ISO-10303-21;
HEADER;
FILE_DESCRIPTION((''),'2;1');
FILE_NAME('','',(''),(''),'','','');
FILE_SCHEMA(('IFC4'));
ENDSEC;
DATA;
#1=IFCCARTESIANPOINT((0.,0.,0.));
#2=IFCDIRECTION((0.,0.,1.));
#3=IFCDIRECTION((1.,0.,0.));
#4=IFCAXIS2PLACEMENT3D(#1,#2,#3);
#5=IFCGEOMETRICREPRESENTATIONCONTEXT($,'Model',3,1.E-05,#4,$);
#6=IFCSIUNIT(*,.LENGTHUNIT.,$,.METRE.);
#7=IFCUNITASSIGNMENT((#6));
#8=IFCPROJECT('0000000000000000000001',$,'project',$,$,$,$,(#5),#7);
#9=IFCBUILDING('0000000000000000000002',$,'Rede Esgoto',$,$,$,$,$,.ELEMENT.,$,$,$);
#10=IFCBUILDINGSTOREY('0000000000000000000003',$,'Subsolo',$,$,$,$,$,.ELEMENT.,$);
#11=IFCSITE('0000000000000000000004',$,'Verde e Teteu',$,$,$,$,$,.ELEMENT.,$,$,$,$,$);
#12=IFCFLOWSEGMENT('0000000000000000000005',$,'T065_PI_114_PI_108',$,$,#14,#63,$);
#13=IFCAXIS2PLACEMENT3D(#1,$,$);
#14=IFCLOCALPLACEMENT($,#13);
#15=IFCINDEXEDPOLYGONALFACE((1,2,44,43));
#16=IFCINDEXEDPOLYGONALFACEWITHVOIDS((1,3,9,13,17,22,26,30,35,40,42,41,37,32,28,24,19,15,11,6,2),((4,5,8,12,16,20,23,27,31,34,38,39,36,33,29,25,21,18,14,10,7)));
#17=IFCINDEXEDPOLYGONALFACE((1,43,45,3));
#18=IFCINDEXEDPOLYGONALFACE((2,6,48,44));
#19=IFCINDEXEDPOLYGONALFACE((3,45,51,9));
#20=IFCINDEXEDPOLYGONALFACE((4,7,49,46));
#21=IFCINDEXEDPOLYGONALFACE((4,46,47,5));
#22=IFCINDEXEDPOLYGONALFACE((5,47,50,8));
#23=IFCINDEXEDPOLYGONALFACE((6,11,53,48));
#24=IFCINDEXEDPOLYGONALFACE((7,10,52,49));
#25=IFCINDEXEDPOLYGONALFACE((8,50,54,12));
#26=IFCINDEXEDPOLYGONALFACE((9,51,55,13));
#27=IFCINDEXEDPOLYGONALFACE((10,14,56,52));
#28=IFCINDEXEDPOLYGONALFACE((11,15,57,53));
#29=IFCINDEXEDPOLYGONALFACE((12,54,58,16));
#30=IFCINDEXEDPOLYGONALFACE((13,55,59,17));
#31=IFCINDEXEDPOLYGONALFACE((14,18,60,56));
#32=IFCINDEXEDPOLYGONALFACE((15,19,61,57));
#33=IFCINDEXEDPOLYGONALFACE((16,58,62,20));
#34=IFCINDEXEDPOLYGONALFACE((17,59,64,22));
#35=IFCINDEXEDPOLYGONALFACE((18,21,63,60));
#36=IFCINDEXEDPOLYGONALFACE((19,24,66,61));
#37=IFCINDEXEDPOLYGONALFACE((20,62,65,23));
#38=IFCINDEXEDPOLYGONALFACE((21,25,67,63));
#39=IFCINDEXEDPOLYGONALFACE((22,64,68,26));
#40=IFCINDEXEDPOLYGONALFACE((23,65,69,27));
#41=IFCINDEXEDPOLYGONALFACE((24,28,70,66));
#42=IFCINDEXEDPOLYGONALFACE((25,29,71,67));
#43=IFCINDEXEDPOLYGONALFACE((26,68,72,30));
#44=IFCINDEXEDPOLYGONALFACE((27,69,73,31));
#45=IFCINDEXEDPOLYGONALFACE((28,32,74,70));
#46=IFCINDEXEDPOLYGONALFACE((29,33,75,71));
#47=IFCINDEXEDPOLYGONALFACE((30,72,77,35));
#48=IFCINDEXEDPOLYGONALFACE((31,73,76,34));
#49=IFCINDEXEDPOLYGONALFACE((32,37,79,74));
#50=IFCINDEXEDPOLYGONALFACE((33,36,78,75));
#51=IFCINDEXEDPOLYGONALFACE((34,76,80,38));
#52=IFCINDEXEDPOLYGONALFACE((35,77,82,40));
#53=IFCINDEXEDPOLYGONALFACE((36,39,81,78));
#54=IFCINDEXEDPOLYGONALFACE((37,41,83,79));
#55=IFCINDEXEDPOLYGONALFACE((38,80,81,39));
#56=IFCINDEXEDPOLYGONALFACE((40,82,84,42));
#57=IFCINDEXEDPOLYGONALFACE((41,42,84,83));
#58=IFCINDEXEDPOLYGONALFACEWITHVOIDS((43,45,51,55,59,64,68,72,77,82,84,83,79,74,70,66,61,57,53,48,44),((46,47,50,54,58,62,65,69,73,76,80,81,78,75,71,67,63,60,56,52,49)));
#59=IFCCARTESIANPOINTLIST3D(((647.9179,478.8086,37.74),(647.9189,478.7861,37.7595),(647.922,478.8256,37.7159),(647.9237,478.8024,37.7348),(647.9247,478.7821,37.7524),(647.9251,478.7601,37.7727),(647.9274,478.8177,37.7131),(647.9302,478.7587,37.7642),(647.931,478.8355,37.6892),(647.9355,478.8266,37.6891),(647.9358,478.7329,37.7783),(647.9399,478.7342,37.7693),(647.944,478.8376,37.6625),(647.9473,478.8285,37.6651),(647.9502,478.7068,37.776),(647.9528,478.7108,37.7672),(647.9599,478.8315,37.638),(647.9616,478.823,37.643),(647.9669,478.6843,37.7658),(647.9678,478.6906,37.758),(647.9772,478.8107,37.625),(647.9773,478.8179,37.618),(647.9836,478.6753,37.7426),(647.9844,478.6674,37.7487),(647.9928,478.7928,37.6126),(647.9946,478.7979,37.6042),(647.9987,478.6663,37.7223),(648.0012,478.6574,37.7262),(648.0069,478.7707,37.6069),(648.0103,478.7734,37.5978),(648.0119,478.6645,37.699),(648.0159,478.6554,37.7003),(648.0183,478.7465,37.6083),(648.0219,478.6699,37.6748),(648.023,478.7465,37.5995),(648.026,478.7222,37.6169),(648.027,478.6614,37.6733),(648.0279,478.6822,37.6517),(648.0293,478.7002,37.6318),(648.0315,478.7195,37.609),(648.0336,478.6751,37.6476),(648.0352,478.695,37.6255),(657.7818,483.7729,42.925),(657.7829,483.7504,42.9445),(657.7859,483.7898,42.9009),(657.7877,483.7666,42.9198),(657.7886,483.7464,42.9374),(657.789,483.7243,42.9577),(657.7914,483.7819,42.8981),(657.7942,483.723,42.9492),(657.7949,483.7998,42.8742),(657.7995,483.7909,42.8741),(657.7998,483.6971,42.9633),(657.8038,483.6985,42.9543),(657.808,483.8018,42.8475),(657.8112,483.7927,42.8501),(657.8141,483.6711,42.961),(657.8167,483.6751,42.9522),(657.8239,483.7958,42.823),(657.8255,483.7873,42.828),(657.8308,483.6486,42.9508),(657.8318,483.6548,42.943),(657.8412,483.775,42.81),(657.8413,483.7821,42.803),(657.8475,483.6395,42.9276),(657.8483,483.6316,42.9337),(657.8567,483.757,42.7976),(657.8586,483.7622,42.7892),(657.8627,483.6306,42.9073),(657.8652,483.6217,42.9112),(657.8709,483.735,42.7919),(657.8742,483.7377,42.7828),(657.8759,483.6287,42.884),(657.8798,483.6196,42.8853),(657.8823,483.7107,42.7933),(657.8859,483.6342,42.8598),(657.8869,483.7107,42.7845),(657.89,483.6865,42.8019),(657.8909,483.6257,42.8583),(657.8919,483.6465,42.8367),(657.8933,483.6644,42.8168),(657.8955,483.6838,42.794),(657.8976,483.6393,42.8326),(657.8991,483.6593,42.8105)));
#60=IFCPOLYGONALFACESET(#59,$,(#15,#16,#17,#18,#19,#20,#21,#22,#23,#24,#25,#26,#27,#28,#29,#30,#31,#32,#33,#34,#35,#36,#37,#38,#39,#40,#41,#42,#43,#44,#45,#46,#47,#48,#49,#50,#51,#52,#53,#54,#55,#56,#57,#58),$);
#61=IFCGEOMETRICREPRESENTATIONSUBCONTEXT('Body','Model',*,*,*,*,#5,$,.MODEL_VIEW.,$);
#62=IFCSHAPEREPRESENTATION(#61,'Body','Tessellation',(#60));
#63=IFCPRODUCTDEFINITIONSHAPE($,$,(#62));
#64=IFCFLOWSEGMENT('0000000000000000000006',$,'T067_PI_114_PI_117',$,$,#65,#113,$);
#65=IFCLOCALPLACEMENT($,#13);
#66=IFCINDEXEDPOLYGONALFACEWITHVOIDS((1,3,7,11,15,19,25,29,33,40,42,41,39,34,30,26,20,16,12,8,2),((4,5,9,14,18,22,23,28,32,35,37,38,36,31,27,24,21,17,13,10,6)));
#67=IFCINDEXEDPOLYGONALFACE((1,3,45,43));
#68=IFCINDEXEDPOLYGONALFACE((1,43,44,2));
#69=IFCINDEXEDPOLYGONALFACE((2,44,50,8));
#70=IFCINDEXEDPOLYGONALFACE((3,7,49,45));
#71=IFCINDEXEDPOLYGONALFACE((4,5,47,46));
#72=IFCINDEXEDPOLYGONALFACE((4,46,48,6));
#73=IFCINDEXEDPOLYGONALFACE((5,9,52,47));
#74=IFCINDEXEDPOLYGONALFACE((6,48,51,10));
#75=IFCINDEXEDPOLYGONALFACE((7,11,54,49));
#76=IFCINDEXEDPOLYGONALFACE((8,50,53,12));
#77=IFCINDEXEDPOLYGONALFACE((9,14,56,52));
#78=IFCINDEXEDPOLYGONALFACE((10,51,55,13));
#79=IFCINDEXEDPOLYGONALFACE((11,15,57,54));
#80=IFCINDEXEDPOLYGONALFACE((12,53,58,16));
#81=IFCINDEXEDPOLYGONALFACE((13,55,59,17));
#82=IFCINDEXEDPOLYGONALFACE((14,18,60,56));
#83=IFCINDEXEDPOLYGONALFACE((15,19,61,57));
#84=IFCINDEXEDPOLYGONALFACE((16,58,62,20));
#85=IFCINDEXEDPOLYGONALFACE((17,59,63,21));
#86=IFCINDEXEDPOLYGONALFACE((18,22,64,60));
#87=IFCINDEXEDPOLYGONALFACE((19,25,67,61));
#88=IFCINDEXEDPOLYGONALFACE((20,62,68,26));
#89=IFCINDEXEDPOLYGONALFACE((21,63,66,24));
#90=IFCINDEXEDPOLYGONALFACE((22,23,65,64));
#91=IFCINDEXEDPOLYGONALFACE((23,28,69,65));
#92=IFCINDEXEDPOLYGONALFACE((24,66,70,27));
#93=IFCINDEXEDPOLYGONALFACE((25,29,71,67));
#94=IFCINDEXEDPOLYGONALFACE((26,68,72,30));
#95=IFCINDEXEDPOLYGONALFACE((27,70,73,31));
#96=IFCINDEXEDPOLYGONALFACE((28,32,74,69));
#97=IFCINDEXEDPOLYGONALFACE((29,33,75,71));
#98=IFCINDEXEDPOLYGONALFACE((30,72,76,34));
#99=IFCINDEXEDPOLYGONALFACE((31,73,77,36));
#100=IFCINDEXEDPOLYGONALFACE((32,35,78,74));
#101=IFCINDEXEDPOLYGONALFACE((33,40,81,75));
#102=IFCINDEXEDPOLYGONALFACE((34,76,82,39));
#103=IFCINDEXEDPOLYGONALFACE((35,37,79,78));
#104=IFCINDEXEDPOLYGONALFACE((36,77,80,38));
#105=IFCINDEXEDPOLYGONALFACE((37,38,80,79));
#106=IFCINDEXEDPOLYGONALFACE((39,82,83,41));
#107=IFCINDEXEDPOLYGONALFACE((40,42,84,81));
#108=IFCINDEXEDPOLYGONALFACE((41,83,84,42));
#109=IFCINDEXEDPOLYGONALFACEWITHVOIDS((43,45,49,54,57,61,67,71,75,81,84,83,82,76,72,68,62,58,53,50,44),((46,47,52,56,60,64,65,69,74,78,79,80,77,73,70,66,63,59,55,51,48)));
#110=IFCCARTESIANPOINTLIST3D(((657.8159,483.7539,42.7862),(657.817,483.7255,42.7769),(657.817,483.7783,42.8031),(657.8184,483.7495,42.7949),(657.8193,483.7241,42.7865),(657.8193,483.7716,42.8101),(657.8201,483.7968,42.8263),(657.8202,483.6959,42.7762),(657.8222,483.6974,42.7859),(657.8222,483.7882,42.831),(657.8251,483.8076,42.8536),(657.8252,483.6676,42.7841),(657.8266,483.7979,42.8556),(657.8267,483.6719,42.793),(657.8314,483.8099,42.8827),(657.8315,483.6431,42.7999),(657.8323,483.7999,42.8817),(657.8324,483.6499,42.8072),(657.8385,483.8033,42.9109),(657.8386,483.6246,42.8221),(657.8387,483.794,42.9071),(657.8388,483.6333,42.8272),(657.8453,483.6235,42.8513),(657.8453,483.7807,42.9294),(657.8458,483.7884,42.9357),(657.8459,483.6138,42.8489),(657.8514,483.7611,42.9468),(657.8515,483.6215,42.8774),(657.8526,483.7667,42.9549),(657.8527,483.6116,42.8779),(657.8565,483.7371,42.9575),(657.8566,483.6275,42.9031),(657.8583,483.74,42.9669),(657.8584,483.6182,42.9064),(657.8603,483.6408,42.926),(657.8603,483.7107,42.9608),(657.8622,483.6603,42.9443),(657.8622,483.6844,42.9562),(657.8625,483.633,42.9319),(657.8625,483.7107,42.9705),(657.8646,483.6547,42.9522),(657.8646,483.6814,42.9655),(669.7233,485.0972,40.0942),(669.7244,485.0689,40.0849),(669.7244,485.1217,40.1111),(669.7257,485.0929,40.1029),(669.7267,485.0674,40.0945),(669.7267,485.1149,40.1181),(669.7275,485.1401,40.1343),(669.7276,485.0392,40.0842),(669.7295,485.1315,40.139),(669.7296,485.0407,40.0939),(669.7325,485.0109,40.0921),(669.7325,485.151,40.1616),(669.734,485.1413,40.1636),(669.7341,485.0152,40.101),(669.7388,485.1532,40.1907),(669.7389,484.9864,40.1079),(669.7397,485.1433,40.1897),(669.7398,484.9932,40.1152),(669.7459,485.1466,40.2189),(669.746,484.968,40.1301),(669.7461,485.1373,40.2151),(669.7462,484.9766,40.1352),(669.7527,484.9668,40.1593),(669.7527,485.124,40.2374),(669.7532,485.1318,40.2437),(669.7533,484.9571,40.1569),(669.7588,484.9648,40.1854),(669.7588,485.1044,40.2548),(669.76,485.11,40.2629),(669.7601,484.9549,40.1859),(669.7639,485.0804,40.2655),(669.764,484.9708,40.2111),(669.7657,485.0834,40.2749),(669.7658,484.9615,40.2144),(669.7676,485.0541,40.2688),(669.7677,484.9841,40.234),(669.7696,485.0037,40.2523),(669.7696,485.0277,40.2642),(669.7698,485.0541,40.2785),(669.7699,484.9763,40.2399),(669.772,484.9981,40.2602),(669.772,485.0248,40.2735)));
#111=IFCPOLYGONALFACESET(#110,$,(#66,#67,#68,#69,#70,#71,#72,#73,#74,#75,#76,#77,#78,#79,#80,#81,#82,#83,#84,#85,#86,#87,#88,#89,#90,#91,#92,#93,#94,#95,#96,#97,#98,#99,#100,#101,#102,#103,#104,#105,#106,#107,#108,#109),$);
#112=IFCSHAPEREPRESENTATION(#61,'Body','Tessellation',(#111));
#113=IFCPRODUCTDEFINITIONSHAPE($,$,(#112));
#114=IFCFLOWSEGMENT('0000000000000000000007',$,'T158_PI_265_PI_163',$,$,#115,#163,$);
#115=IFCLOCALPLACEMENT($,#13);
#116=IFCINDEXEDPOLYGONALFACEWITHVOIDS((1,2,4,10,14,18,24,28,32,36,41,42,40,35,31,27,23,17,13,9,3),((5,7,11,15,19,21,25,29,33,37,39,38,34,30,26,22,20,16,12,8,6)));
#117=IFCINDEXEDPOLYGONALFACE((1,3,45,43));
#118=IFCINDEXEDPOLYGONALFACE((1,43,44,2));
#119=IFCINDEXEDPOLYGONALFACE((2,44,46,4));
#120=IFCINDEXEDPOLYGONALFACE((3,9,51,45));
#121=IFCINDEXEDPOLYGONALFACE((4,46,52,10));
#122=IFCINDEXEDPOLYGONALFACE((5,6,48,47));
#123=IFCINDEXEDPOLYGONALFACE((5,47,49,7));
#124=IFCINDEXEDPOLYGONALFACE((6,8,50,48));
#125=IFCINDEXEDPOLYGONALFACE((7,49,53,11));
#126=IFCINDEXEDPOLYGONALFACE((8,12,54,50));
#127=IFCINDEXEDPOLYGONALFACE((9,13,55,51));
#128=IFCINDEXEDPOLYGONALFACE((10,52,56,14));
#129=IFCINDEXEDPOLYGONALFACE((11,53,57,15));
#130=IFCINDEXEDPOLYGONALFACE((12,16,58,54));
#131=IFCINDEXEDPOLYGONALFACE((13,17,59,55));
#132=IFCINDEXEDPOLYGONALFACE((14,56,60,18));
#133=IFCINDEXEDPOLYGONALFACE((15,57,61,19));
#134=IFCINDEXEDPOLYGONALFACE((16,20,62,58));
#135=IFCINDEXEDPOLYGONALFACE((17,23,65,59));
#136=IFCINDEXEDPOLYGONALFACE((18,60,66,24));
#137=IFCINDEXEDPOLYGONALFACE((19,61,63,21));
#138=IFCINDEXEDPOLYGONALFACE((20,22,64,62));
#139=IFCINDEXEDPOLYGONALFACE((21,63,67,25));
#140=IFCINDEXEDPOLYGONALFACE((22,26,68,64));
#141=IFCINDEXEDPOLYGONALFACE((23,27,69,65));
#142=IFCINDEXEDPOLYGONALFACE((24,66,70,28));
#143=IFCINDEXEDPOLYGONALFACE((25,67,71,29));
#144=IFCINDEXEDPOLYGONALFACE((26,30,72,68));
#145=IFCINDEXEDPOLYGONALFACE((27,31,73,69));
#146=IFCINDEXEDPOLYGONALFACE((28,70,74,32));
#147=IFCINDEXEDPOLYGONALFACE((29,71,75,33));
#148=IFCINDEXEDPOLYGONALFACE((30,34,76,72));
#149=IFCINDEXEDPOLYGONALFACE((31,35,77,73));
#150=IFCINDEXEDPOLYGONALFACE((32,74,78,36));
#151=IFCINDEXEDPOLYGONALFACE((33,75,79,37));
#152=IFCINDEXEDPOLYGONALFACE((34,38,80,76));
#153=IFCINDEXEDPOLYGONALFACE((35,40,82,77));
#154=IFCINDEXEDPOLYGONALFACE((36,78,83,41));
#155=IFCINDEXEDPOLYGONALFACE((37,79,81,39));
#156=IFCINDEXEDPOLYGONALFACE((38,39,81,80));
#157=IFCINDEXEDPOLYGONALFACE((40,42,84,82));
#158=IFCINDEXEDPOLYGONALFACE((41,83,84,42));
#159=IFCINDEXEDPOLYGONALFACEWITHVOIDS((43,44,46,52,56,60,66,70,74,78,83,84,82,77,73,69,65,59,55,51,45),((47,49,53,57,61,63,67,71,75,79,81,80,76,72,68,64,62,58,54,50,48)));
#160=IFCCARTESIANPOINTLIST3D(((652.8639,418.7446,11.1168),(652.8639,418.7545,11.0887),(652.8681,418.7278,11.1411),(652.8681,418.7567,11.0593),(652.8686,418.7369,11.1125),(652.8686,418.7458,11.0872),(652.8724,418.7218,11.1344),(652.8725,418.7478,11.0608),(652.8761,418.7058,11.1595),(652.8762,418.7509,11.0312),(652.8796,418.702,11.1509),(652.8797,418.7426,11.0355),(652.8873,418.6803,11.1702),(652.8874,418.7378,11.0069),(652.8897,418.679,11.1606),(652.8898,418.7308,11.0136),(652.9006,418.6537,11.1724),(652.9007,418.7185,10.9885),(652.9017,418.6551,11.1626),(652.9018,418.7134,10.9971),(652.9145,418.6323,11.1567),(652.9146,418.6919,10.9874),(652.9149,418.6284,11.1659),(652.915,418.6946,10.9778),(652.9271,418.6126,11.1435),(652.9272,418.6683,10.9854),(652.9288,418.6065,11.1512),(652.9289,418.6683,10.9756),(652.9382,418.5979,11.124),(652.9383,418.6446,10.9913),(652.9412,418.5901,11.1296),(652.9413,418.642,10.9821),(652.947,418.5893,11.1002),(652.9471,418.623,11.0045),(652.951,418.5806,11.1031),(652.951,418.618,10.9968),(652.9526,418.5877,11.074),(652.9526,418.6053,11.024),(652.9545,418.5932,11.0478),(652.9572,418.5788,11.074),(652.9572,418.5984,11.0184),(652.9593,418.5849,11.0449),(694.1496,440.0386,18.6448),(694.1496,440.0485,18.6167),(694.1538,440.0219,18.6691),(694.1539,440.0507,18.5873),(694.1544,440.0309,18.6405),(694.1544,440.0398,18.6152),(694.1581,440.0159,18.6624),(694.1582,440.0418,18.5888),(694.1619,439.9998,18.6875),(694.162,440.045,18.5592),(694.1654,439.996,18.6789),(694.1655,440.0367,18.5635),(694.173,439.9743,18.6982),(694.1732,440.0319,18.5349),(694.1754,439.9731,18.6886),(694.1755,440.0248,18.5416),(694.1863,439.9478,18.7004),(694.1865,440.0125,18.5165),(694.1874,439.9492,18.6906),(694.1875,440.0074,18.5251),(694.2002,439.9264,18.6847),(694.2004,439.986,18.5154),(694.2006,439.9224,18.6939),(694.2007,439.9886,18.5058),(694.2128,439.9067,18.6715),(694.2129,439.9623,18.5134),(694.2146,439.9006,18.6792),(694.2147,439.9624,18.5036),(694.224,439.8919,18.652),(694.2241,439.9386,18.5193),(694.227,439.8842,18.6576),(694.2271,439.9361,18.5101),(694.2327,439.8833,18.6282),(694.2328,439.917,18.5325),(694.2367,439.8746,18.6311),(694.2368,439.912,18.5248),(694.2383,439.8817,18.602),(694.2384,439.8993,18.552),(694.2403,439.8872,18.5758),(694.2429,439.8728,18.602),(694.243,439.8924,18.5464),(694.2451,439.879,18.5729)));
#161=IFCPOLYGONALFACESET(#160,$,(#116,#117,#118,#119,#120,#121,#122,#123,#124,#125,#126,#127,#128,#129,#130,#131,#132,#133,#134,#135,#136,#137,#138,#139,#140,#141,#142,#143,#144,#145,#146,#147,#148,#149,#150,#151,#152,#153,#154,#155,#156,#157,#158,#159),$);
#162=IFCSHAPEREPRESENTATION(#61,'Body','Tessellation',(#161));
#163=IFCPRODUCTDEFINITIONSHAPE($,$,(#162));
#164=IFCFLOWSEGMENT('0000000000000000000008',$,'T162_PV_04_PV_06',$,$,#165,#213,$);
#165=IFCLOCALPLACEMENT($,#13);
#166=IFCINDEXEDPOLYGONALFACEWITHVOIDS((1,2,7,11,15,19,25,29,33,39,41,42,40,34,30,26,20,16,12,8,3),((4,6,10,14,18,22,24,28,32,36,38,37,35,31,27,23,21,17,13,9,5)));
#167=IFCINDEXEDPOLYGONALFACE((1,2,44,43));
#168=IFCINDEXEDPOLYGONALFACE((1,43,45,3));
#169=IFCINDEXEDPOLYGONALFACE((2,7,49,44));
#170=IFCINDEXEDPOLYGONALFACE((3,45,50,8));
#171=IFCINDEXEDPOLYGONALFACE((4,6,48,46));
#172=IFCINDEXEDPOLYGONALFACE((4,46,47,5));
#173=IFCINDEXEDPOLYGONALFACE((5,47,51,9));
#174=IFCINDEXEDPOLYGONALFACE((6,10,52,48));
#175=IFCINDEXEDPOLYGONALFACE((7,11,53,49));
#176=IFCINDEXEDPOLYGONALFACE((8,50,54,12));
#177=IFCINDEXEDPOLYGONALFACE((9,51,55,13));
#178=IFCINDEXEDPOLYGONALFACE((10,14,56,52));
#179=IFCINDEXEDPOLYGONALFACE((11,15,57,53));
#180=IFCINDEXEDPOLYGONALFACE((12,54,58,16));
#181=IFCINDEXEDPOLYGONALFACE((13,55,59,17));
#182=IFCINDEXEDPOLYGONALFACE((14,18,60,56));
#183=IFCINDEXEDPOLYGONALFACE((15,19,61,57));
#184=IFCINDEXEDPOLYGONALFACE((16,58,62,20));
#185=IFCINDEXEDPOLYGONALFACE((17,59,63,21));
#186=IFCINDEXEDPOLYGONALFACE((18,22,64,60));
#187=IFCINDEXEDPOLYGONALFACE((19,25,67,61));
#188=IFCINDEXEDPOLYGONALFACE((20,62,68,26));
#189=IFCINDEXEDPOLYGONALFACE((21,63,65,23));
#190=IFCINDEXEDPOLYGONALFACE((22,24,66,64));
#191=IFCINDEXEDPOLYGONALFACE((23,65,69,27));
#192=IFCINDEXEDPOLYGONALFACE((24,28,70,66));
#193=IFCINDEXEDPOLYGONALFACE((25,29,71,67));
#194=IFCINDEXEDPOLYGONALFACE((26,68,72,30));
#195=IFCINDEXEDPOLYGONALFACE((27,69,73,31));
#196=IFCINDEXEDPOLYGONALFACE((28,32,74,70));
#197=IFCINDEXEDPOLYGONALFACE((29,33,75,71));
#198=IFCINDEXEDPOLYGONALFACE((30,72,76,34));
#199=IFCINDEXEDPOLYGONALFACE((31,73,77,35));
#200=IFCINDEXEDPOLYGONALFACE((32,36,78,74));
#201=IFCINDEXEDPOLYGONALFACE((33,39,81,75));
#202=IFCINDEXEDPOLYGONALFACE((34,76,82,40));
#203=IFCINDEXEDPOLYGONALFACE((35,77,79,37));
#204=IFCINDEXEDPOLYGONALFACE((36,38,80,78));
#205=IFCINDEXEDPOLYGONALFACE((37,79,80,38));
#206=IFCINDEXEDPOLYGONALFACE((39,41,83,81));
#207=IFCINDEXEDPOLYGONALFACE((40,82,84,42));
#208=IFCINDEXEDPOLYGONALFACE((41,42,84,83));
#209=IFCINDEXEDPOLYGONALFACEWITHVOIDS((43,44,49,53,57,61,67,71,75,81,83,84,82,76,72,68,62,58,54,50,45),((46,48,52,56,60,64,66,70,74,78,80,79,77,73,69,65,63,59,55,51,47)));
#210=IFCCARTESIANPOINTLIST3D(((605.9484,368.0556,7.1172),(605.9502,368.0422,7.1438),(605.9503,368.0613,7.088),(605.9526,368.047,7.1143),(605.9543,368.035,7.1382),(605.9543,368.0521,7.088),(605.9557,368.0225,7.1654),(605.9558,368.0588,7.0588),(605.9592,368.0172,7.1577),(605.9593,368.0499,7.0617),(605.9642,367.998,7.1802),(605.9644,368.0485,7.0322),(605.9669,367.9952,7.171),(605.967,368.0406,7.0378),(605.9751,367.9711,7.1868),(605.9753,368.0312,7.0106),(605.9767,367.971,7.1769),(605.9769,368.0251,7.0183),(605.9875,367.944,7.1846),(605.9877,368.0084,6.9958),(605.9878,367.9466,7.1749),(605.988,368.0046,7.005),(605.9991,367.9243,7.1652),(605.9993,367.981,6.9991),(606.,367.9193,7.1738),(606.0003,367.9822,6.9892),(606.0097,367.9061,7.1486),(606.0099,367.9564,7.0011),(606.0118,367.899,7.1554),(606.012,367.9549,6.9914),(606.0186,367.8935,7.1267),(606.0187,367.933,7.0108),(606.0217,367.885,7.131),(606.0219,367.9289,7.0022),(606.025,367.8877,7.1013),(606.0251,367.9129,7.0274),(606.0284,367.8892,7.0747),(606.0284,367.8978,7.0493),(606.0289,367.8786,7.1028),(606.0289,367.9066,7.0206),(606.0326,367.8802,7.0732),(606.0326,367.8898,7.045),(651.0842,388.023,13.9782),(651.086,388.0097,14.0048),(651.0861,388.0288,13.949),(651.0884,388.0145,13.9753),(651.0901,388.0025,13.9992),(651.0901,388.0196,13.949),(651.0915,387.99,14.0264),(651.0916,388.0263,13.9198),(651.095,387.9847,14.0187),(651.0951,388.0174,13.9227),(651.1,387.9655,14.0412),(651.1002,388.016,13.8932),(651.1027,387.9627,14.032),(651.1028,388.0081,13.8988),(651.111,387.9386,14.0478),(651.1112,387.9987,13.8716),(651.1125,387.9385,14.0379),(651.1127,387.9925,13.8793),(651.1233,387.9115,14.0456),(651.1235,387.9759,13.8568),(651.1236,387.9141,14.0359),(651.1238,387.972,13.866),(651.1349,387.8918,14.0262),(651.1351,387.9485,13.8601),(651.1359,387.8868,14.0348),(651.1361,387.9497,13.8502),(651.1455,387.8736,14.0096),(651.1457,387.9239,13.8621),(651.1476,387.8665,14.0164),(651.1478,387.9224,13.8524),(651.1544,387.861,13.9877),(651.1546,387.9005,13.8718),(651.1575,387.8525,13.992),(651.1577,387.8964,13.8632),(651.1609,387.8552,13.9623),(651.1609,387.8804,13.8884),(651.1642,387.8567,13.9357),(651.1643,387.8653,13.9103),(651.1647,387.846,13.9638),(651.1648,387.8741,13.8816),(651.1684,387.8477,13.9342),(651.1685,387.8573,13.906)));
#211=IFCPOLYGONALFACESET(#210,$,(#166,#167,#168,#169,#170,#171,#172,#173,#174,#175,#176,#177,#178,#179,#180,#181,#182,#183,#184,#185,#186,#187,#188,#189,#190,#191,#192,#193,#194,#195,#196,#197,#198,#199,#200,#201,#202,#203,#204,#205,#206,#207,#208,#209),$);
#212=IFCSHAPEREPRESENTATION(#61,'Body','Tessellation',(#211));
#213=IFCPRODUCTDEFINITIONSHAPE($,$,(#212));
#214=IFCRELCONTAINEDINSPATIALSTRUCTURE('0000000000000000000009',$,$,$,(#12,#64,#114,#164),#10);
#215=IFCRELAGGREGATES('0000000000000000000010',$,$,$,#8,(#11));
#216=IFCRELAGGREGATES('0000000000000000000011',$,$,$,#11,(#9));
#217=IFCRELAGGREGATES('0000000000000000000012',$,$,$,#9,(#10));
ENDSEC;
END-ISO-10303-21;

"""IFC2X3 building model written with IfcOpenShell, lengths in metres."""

from ifc_helpers import new_model, entity, si_unit, frame, origin_with_axes, place, context, subcontext, project, spatial, element, save


model = new_model("IFC2X3")

# Units and contexts
model_context = context("Model", 3, precision=1e-05, world=origin_with_axes())
body_context = subcontext(model_context, "Body", "Model", "MODEL_VIEW")
ifc_project = project(units=[si_unit("LENGTHUNIT", "METRE")], contexts=[model_context])

# Site, building, storey
site = spatial("IfcSite", under=ifc_project, Name="Verde e Teteu", CompositionType="ELEMENT")
building = spatial("IfcBuilding", under=site, Name="Rede Esgoto", CompositionType="ELEMENT")
storey = spatial("IfcBuildingStorey", under=building, Name="Subsolo", CompositionType="ELEMENT")

# Flow segments
flow_segment_1_placement = place(None, frame((657.8404, 483.7107, 42.873), z_axis=(0.0, 0.0, 1.0), x_axis=(1.0, 0.0, 0.0)))
element("IfcFlowSegment", 1, at=flow_segment_1_placement, inside=storey, Name="T065_PI_114_PI_108", context=body_context, shape_type="SweptSolid", body=[
    entity("IfcSweptDiskSolid", entity("IfcPolyline", [entity("IfcCartesianPoint", [0.0, 0.0, 0.0]), entity("IfcCartesianPoint", [-9.8639, -4.9643, -5.185])]), 0.1, 0.09),
])
flow_segment_2_placement = place(None, frame((657.8404, 483.7107, 42.873), z_axis=(0.0, 0.0, 1.0), x_axis=(1.0, 0.0, 0.0)))
element("IfcFlowSegment", 2, at=flow_segment_2_placement, inside=storey, Name="T067_PI_114_PI_117", context=body_context, shape_type="SweptSolid", body=[
    entity("IfcSweptDiskSolid", entity("IfcPolyline", [entity("IfcCartesianPoint", [0.0, 0.0, 0.0]), entity("IfcCartesianPoint", [11.9074, 1.3433, -2.692])]), 0.1, 0.09),
])
flow_segment_3_placement = place(None, frame((694.1971, 439.9617, 18.602), z_axis=(0.0, 0.0, 1.0), x_axis=(1.0, 0.0, 0.0)))
element("IfcFlowSegment", 3, at=flow_segment_3_placement, inside=storey, Name="T158_PI_265_PI_163", context=body_context, shape_type="SweptSolid", body=[
    entity("IfcSweptDiskSolid", entity("IfcPolyline", [entity("IfcCartesianPoint", [0.0, 0.0, 0.0]), entity("IfcCartesianPoint", [-41.2857, -21.294, -7.528])]), 0.1, 0.09),
])
flow_segment_4_placement = place(None, frame((605.9907, 367.9698, 7.088), z_axis=(0.0, 0.0, 1.0), x_axis=(1.0, 0.0, 0.0)))
element("IfcFlowSegment", 4, at=flow_segment_4_placement, inside=storey, Name="T162_PV_04_PV_06", context=body_context, shape_type="SweptSolid", body=[
    entity("IfcSweptDiskSolid", entity("IfcPolyline", [entity("IfcCartesianPoint", [0.0, 0.0, 0.0]), entity("IfcCartesianPoint", [45.1358, 19.9675, 6.861])]), 0.1, 0.09),
])

save(model, "model.ifc")
